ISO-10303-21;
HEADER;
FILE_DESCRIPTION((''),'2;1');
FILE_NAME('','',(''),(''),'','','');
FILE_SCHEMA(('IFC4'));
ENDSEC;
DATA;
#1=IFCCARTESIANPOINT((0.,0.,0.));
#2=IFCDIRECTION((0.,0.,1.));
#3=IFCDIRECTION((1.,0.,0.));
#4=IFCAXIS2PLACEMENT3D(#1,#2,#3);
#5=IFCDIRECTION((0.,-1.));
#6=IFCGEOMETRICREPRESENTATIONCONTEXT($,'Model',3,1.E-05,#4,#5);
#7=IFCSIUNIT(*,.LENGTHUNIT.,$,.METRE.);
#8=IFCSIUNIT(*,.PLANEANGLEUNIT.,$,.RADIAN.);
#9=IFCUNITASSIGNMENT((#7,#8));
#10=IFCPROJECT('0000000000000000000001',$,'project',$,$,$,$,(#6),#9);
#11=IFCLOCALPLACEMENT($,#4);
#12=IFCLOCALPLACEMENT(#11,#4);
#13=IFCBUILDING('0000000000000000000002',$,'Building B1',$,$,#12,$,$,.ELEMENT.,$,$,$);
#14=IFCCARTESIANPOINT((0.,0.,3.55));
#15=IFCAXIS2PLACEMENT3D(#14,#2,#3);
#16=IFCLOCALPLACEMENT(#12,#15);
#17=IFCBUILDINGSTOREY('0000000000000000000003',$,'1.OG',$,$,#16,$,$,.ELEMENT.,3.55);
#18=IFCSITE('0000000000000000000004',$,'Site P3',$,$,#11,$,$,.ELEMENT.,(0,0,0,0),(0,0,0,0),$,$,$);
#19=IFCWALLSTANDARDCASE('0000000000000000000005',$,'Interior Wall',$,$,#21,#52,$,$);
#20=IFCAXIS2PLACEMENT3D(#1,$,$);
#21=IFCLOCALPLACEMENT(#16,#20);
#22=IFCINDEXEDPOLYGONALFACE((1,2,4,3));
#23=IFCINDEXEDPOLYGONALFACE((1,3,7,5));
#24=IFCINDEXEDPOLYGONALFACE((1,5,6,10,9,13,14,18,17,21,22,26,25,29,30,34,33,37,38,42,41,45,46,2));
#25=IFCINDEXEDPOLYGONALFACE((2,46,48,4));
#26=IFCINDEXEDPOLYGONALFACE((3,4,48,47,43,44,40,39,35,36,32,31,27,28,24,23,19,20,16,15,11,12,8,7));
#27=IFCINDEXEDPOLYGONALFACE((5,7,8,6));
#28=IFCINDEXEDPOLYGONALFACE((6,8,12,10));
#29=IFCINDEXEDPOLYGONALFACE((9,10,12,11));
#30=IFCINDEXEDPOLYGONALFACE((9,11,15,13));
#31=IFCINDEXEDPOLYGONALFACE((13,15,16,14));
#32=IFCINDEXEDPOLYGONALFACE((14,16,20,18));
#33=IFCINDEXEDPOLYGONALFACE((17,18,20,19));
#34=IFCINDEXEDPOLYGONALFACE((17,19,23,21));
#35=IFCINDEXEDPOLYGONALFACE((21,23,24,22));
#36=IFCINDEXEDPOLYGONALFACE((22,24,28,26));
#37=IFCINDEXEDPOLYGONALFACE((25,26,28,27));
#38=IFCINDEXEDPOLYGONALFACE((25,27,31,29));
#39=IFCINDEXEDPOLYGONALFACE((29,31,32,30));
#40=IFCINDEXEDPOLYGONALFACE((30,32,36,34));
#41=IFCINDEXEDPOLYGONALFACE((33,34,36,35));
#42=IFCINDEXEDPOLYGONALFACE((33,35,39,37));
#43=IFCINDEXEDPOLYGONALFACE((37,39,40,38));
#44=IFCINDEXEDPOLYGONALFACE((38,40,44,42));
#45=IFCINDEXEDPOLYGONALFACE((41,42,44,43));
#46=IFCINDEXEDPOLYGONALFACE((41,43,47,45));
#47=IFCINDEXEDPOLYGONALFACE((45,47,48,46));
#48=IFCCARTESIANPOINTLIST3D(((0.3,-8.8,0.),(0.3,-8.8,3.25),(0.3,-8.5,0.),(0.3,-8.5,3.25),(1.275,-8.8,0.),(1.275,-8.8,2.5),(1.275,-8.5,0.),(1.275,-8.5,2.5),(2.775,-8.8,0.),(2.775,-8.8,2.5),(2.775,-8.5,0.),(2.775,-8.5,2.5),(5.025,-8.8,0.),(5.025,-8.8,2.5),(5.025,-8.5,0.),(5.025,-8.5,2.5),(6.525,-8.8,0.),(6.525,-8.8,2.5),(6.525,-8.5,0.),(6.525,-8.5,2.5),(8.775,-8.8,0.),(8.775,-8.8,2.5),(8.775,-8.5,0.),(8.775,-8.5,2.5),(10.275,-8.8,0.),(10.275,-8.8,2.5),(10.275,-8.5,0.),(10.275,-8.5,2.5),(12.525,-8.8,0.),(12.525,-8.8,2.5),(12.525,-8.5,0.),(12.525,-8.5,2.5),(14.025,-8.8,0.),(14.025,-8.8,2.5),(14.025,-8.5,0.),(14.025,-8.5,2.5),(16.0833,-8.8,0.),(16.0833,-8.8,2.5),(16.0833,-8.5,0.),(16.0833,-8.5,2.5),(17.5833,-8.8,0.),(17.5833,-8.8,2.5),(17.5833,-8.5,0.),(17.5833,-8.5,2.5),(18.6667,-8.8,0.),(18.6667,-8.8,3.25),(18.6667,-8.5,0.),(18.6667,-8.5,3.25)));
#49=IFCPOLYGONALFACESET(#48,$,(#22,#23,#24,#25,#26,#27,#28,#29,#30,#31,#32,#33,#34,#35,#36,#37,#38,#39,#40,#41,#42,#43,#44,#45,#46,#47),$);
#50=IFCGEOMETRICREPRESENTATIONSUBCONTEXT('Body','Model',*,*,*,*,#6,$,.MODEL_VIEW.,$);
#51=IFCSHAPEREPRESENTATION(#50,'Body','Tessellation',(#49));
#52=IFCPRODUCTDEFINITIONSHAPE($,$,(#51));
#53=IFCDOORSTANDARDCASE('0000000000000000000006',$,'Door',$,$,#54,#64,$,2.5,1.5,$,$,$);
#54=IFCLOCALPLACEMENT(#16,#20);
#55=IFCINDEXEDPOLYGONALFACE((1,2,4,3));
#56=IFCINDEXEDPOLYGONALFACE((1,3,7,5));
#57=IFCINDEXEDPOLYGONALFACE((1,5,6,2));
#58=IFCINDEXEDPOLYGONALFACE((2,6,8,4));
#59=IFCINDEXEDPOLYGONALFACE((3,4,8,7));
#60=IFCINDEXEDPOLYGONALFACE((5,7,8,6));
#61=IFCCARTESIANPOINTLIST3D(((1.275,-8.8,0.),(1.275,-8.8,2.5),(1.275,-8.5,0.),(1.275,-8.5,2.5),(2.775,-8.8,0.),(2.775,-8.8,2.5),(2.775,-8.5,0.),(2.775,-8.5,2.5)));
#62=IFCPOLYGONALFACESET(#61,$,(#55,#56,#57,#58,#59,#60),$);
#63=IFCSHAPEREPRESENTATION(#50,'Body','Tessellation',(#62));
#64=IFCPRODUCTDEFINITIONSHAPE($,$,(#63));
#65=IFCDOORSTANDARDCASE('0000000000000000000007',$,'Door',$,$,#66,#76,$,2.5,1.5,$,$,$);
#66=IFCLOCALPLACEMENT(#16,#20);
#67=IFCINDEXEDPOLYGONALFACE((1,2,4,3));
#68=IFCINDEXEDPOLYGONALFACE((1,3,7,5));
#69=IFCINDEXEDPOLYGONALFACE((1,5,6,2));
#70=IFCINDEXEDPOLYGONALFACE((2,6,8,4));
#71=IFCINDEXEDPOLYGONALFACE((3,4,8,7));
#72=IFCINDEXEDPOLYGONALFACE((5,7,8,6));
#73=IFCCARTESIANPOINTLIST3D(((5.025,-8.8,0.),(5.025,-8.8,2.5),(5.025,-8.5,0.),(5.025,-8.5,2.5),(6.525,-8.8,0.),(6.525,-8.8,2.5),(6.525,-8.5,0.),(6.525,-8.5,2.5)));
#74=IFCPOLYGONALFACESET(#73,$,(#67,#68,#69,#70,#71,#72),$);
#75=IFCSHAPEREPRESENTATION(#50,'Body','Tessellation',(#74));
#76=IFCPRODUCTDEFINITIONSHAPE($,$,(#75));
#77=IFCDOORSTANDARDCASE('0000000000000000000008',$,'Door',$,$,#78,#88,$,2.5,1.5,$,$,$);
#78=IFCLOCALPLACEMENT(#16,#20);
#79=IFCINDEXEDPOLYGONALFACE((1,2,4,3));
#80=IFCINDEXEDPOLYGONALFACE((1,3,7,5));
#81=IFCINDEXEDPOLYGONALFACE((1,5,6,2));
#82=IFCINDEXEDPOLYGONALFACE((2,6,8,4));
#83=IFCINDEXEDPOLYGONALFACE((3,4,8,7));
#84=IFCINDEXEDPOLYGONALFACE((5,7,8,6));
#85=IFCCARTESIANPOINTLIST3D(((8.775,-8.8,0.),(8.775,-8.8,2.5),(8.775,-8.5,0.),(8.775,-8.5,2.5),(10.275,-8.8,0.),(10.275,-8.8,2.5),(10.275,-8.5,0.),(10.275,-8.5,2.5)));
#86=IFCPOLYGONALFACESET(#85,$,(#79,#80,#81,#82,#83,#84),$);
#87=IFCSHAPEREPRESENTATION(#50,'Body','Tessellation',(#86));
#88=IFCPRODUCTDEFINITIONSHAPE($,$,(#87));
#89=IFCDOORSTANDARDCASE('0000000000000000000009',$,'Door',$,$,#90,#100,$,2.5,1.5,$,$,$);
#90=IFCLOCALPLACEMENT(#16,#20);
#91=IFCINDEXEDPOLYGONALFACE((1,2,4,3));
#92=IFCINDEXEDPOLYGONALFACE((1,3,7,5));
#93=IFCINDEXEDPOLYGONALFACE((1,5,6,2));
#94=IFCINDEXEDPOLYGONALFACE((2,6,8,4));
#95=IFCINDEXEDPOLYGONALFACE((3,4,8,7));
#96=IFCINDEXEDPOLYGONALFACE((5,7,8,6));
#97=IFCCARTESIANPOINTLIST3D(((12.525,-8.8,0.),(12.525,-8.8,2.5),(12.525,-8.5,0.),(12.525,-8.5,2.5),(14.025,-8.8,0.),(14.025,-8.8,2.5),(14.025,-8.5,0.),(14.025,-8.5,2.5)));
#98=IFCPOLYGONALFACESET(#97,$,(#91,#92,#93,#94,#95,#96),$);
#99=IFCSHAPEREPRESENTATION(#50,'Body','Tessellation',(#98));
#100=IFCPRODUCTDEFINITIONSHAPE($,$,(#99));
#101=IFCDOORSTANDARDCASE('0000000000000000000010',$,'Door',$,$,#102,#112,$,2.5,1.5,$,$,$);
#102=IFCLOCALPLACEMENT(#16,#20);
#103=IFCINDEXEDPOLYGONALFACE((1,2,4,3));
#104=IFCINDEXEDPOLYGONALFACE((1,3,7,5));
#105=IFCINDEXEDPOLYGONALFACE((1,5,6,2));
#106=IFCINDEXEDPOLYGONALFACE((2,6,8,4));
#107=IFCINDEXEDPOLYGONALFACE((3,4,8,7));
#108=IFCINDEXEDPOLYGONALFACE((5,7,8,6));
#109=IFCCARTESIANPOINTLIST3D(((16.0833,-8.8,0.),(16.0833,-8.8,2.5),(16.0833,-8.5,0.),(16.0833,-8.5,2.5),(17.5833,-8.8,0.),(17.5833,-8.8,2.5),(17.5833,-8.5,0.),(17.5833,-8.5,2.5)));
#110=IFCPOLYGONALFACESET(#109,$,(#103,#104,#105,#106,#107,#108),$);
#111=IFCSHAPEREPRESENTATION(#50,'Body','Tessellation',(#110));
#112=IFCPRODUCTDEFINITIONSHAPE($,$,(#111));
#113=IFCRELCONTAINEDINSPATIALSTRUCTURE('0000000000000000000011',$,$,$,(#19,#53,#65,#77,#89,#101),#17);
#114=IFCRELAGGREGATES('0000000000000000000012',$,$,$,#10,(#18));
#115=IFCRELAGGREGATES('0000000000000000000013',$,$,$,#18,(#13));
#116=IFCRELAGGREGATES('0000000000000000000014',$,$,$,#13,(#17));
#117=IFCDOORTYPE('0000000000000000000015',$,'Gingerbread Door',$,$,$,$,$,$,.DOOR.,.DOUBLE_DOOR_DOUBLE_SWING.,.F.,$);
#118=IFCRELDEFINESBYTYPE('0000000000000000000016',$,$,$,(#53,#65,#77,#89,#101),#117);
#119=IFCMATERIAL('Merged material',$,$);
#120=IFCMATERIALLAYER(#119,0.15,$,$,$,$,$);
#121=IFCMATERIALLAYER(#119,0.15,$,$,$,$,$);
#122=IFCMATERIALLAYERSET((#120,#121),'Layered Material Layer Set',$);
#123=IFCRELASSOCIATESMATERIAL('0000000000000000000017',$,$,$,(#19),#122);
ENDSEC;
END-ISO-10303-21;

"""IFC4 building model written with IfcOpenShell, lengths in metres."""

from ifc_helpers import new_model, si_unit, direction, frame, origin_with_axes, place, context, subcontext, project, spatial, polyline, outline, extrude, source, transform, mapped, material, layer, layer_set, layer_usage, type_object, element, fill, save


model = new_model("IFC4")

# Units and contexts
model_context = context("Model", 3, precision=1e-05, world=origin_with_axes(), true_north=direction((0.0, -1.0)))
body_context = subcontext(model_context, "Body", "Model", "MODEL_VIEW")
ifc_project = project(units=[si_unit("LENGTHUNIT", "METRE"), si_unit("PLANEANGLEUNIT", "RADIAN")], contexts=[model_context])

# Site, building, storey
site_placement = place(None, origin_with_axes())
site = spatial("IfcSite", under=ifc_project, at=site_placement, Name="Site P3", CompositionType="ELEMENT", RefLatitude=(0, 0, 0, 0), RefLongitude=(0, 0, 0, 0))
building_placement = place(site_placement, origin_with_axes())
building = spatial("IfcBuilding", under=site, at=building_placement, Name="Building B1", CompositionType="ELEMENT")
storey_placement = place(building_placement, frame((0.0, 0.0, 3.55), z_axis=(0.0, 0.0, 1.0), x_axis=(1.0, 0.0, 0.0)))
storey = spatial("IfcBuildingStorey", under=building, at=storey_placement, Name="1.OG", CompositionType="ELEMENT", Elevation=3.55)

# Shared definitions
ifc_material = material(Name="Merged material")

# Wall, openings, doors
ifc_layer_1 = layer(ifc_material, 0.15)
ifc_layer_2 = layer(ifc_material, 0.15)
ifc_layer_set_1 = layer_set([ifc_layer_1, ifc_layer_2], Name="Layered Material Layer Set")
ifc_layer_usage_1 = layer_usage(ifc_layer_set_1, "AXIS2", "POSITIVE", -0.15)
wall_1_placement = place(storey_placement, frame((0.3, -8.65, 0.0), z_axis=(0.0, 0.0, 1.0), x_axis=(1.0, 0.0, 0.0)))
wall_1 = element("IfcWallStandardCase", 1, at=wall_1_placement, inside=storey, material=ifc_layer_usage_1, Name="Interior Wall", context=body_context, shape_type="SweptSolid", body=[
    extrude(outline(polyline([(0.0, 0.15), (18.3667, 0.15), (18.3667, -0.15), (0.0, -0.15), (0.0, 0.15)])), origin_with_axes(), (0.0, 0.0, 1.0), 3.25),
])
opening_1_placement = place(wall_1_placement, frame((0.975, 0.0, 0.0), z_axis=(0.0, 0.0, 1.0), x_axis=(1.0, 0.0, 0.0)))
opening_1 = element("IfcOpeningStandardCase", 2, at=opening_1_placement, cuts=wall_1, context=body_context, shape_type="SweptSolid", body=[
    extrude(outline(polyline([(0.0, 0.0), (0.0, 1.5), (2.5, 1.5), (2.5, 0.0), (0.0, 0.0)])), frame((0.0, -0.15, 0.0), z_axis=(0.0, 1.0, 0.0), x_axis=(0.0, 0.0, 1.0)), (0.0, 0.0, 1.0), 0.3),
])
opening_2_placement = place(wall_1_placement, frame((4.725, 0.0, 0.0), z_axis=(0.0, 0.0, 1.0), x_axis=(1.0, 0.0, 0.0)))
opening_2 = element("IfcOpeningStandardCase", 3, at=opening_2_placement, cuts=wall_1, context=body_context, shape_type="SweptSolid", body=[
    extrude(outline(polyline([(0.0, 0.0), (0.0, 1.5), (2.5, 1.5), (2.5, 0.0), (0.0, 0.0)])), frame((0.0, -0.15, 0.0), z_axis=(0.0, 1.0, 0.0), x_axis=(0.0, 0.0, 1.0)), (0.0, 0.0, 1.0), 0.3),
])
opening_3_placement = place(wall_1_placement, frame((8.475, 0.0, 0.0), z_axis=(0.0, 0.0, 1.0), x_axis=(1.0, 0.0, 0.0)))
opening_3 = element("IfcOpeningStandardCase", 4, at=opening_3_placement, cuts=wall_1, context=body_context, shape_type="SweptSolid", body=[
    extrude(outline(polyline([(0.0, 0.0), (0.0, 1.5), (2.5, 1.5), (2.5, 0.0), (0.0, 0.0)])), frame((0.0, -0.15, 0.0), z_axis=(0.0, 1.0, 0.0), x_axis=(0.0, 0.0, 1.0)), (0.0, 0.0, 1.0), 0.3),
])
opening_4_placement = place(wall_1_placement, frame((12.225, 0.0, 0.0), z_axis=(0.0, 0.0, 1.0), x_axis=(1.0, 0.0, 0.0)))
opening_4 = element("IfcOpeningStandardCase", 5, at=opening_4_placement, cuts=wall_1, context=body_context, shape_type="SweptSolid", body=[
    extrude(outline(polyline([(0.0, 0.0), (0.0, 1.5), (2.5, 1.5), (2.5, 0.0), (0.0, 0.0)])), frame((0.0, -0.15, 0.0), z_axis=(0.0, 1.0, 0.0), x_axis=(0.0, 0.0, 1.0)), (0.0, 0.0, 1.0), 0.3),
])
opening_5_placement = place(wall_1_placement, frame((15.7833, 0.0, 0.0), z_axis=(0.0, 0.0, 1.0), x_axis=(1.0, 0.0, 0.0)))
opening_5 = element("IfcOpeningStandardCase", 6, at=opening_5_placement, cuts=wall_1, context=body_context, shape_type="SweptSolid", body=[
    extrude(outline(polyline([(0.0, 0.0), (0.0, 1.5), (2.5, 1.5), (2.5, 0.0), (0.0, 0.0)])), frame((0.0, -0.15, 0.0), z_axis=(0.0, 1.0, 0.0), x_axis=(0.0, 0.0, 1.0)), (0.0, 0.0, 1.0), 0.3),
])
door_type = type_object("IfcDoorType", Name="Gingerbread Door", OperationType="DOUBLE_DOOR_DOUBLE_SWING", ParameterTakesPrecedence=False, PredefinedType="DOOR")
shared_shape_1 = source(origin_with_axes(), body_context, "Body", "SweptSolid", [
    extrude(outline(polyline([(0.0, 0.0), (0.0, 1.5), (2.5, 1.5), (2.5, 0.0), (0.0, 0.0)])), frame((0.0, -0.15, 0.0), z_axis=(0.0, 1.0, 0.0), x_axis=(0.0, 0.0, 1.0)), (0.0, 0.0, 1.0), 0.3),
])
door_1_placement = place(opening_1_placement, origin_with_axes())
door_1 = element("IfcDoorStandardCase", 7, at=door_1_placement, inside=storey, type_object=door_type, Name="Door", OverallHeight=2.5, OverallWidth=1.5, context=body_context, shape_type="MappedRepresentation", body=[
    mapped(shared_shape_1, transform((0.0, 0.0, 0.0))),
])
fill(opening_1, door_1)
door_2_placement = place(opening_2_placement, origin_with_axes())
door_2 = element("IfcDoorStandardCase", 8, at=door_2_placement, inside=storey, type_object=door_type, Name="Door", OverallHeight=2.5, OverallWidth=1.5, context=body_context, shape_type="MappedRepresentation", body=[
    mapped(shared_shape_1, transform((0.0, 0.0, 0.0))),
])
fill(opening_2, door_2)
door_3_placement = place(opening_3_placement, origin_with_axes())
door_3 = element("IfcDoorStandardCase", 9, at=door_3_placement, inside=storey, type_object=door_type, Name="Door", OverallHeight=2.5, OverallWidth=1.5, context=body_context, shape_type="MappedRepresentation", body=[
    mapped(shared_shape_1, transform((0.0, 0.0, 0.0))),
])
fill(opening_3, door_3)
door_4_placement = place(opening_4_placement, origin_with_axes())
door_4 = element("IfcDoorStandardCase", 10, at=door_4_placement, inside=storey, type_object=door_type, Name="Door", OverallHeight=2.5, OverallWidth=1.5, context=body_context, shape_type="MappedRepresentation", body=[
    mapped(shared_shape_1, transform((0.0, 0.0, 0.0))),
])
fill(opening_4, door_4)
door_5_placement = place(opening_5_placement, origin_with_axes())
door_5 = element("IfcDoorStandardCase", 11, at=door_5_placement, inside=storey, type_object=door_type, Name="Door", OverallHeight=2.5, OverallWidth=1.5, context=body_context, shape_type="MappedRepresentation", body=[
    mapped(shared_shape_1, transform((0.0, 0.0, 0.0))),
])
fill(opening_5, door_5)

save(model, "model.ifc")
